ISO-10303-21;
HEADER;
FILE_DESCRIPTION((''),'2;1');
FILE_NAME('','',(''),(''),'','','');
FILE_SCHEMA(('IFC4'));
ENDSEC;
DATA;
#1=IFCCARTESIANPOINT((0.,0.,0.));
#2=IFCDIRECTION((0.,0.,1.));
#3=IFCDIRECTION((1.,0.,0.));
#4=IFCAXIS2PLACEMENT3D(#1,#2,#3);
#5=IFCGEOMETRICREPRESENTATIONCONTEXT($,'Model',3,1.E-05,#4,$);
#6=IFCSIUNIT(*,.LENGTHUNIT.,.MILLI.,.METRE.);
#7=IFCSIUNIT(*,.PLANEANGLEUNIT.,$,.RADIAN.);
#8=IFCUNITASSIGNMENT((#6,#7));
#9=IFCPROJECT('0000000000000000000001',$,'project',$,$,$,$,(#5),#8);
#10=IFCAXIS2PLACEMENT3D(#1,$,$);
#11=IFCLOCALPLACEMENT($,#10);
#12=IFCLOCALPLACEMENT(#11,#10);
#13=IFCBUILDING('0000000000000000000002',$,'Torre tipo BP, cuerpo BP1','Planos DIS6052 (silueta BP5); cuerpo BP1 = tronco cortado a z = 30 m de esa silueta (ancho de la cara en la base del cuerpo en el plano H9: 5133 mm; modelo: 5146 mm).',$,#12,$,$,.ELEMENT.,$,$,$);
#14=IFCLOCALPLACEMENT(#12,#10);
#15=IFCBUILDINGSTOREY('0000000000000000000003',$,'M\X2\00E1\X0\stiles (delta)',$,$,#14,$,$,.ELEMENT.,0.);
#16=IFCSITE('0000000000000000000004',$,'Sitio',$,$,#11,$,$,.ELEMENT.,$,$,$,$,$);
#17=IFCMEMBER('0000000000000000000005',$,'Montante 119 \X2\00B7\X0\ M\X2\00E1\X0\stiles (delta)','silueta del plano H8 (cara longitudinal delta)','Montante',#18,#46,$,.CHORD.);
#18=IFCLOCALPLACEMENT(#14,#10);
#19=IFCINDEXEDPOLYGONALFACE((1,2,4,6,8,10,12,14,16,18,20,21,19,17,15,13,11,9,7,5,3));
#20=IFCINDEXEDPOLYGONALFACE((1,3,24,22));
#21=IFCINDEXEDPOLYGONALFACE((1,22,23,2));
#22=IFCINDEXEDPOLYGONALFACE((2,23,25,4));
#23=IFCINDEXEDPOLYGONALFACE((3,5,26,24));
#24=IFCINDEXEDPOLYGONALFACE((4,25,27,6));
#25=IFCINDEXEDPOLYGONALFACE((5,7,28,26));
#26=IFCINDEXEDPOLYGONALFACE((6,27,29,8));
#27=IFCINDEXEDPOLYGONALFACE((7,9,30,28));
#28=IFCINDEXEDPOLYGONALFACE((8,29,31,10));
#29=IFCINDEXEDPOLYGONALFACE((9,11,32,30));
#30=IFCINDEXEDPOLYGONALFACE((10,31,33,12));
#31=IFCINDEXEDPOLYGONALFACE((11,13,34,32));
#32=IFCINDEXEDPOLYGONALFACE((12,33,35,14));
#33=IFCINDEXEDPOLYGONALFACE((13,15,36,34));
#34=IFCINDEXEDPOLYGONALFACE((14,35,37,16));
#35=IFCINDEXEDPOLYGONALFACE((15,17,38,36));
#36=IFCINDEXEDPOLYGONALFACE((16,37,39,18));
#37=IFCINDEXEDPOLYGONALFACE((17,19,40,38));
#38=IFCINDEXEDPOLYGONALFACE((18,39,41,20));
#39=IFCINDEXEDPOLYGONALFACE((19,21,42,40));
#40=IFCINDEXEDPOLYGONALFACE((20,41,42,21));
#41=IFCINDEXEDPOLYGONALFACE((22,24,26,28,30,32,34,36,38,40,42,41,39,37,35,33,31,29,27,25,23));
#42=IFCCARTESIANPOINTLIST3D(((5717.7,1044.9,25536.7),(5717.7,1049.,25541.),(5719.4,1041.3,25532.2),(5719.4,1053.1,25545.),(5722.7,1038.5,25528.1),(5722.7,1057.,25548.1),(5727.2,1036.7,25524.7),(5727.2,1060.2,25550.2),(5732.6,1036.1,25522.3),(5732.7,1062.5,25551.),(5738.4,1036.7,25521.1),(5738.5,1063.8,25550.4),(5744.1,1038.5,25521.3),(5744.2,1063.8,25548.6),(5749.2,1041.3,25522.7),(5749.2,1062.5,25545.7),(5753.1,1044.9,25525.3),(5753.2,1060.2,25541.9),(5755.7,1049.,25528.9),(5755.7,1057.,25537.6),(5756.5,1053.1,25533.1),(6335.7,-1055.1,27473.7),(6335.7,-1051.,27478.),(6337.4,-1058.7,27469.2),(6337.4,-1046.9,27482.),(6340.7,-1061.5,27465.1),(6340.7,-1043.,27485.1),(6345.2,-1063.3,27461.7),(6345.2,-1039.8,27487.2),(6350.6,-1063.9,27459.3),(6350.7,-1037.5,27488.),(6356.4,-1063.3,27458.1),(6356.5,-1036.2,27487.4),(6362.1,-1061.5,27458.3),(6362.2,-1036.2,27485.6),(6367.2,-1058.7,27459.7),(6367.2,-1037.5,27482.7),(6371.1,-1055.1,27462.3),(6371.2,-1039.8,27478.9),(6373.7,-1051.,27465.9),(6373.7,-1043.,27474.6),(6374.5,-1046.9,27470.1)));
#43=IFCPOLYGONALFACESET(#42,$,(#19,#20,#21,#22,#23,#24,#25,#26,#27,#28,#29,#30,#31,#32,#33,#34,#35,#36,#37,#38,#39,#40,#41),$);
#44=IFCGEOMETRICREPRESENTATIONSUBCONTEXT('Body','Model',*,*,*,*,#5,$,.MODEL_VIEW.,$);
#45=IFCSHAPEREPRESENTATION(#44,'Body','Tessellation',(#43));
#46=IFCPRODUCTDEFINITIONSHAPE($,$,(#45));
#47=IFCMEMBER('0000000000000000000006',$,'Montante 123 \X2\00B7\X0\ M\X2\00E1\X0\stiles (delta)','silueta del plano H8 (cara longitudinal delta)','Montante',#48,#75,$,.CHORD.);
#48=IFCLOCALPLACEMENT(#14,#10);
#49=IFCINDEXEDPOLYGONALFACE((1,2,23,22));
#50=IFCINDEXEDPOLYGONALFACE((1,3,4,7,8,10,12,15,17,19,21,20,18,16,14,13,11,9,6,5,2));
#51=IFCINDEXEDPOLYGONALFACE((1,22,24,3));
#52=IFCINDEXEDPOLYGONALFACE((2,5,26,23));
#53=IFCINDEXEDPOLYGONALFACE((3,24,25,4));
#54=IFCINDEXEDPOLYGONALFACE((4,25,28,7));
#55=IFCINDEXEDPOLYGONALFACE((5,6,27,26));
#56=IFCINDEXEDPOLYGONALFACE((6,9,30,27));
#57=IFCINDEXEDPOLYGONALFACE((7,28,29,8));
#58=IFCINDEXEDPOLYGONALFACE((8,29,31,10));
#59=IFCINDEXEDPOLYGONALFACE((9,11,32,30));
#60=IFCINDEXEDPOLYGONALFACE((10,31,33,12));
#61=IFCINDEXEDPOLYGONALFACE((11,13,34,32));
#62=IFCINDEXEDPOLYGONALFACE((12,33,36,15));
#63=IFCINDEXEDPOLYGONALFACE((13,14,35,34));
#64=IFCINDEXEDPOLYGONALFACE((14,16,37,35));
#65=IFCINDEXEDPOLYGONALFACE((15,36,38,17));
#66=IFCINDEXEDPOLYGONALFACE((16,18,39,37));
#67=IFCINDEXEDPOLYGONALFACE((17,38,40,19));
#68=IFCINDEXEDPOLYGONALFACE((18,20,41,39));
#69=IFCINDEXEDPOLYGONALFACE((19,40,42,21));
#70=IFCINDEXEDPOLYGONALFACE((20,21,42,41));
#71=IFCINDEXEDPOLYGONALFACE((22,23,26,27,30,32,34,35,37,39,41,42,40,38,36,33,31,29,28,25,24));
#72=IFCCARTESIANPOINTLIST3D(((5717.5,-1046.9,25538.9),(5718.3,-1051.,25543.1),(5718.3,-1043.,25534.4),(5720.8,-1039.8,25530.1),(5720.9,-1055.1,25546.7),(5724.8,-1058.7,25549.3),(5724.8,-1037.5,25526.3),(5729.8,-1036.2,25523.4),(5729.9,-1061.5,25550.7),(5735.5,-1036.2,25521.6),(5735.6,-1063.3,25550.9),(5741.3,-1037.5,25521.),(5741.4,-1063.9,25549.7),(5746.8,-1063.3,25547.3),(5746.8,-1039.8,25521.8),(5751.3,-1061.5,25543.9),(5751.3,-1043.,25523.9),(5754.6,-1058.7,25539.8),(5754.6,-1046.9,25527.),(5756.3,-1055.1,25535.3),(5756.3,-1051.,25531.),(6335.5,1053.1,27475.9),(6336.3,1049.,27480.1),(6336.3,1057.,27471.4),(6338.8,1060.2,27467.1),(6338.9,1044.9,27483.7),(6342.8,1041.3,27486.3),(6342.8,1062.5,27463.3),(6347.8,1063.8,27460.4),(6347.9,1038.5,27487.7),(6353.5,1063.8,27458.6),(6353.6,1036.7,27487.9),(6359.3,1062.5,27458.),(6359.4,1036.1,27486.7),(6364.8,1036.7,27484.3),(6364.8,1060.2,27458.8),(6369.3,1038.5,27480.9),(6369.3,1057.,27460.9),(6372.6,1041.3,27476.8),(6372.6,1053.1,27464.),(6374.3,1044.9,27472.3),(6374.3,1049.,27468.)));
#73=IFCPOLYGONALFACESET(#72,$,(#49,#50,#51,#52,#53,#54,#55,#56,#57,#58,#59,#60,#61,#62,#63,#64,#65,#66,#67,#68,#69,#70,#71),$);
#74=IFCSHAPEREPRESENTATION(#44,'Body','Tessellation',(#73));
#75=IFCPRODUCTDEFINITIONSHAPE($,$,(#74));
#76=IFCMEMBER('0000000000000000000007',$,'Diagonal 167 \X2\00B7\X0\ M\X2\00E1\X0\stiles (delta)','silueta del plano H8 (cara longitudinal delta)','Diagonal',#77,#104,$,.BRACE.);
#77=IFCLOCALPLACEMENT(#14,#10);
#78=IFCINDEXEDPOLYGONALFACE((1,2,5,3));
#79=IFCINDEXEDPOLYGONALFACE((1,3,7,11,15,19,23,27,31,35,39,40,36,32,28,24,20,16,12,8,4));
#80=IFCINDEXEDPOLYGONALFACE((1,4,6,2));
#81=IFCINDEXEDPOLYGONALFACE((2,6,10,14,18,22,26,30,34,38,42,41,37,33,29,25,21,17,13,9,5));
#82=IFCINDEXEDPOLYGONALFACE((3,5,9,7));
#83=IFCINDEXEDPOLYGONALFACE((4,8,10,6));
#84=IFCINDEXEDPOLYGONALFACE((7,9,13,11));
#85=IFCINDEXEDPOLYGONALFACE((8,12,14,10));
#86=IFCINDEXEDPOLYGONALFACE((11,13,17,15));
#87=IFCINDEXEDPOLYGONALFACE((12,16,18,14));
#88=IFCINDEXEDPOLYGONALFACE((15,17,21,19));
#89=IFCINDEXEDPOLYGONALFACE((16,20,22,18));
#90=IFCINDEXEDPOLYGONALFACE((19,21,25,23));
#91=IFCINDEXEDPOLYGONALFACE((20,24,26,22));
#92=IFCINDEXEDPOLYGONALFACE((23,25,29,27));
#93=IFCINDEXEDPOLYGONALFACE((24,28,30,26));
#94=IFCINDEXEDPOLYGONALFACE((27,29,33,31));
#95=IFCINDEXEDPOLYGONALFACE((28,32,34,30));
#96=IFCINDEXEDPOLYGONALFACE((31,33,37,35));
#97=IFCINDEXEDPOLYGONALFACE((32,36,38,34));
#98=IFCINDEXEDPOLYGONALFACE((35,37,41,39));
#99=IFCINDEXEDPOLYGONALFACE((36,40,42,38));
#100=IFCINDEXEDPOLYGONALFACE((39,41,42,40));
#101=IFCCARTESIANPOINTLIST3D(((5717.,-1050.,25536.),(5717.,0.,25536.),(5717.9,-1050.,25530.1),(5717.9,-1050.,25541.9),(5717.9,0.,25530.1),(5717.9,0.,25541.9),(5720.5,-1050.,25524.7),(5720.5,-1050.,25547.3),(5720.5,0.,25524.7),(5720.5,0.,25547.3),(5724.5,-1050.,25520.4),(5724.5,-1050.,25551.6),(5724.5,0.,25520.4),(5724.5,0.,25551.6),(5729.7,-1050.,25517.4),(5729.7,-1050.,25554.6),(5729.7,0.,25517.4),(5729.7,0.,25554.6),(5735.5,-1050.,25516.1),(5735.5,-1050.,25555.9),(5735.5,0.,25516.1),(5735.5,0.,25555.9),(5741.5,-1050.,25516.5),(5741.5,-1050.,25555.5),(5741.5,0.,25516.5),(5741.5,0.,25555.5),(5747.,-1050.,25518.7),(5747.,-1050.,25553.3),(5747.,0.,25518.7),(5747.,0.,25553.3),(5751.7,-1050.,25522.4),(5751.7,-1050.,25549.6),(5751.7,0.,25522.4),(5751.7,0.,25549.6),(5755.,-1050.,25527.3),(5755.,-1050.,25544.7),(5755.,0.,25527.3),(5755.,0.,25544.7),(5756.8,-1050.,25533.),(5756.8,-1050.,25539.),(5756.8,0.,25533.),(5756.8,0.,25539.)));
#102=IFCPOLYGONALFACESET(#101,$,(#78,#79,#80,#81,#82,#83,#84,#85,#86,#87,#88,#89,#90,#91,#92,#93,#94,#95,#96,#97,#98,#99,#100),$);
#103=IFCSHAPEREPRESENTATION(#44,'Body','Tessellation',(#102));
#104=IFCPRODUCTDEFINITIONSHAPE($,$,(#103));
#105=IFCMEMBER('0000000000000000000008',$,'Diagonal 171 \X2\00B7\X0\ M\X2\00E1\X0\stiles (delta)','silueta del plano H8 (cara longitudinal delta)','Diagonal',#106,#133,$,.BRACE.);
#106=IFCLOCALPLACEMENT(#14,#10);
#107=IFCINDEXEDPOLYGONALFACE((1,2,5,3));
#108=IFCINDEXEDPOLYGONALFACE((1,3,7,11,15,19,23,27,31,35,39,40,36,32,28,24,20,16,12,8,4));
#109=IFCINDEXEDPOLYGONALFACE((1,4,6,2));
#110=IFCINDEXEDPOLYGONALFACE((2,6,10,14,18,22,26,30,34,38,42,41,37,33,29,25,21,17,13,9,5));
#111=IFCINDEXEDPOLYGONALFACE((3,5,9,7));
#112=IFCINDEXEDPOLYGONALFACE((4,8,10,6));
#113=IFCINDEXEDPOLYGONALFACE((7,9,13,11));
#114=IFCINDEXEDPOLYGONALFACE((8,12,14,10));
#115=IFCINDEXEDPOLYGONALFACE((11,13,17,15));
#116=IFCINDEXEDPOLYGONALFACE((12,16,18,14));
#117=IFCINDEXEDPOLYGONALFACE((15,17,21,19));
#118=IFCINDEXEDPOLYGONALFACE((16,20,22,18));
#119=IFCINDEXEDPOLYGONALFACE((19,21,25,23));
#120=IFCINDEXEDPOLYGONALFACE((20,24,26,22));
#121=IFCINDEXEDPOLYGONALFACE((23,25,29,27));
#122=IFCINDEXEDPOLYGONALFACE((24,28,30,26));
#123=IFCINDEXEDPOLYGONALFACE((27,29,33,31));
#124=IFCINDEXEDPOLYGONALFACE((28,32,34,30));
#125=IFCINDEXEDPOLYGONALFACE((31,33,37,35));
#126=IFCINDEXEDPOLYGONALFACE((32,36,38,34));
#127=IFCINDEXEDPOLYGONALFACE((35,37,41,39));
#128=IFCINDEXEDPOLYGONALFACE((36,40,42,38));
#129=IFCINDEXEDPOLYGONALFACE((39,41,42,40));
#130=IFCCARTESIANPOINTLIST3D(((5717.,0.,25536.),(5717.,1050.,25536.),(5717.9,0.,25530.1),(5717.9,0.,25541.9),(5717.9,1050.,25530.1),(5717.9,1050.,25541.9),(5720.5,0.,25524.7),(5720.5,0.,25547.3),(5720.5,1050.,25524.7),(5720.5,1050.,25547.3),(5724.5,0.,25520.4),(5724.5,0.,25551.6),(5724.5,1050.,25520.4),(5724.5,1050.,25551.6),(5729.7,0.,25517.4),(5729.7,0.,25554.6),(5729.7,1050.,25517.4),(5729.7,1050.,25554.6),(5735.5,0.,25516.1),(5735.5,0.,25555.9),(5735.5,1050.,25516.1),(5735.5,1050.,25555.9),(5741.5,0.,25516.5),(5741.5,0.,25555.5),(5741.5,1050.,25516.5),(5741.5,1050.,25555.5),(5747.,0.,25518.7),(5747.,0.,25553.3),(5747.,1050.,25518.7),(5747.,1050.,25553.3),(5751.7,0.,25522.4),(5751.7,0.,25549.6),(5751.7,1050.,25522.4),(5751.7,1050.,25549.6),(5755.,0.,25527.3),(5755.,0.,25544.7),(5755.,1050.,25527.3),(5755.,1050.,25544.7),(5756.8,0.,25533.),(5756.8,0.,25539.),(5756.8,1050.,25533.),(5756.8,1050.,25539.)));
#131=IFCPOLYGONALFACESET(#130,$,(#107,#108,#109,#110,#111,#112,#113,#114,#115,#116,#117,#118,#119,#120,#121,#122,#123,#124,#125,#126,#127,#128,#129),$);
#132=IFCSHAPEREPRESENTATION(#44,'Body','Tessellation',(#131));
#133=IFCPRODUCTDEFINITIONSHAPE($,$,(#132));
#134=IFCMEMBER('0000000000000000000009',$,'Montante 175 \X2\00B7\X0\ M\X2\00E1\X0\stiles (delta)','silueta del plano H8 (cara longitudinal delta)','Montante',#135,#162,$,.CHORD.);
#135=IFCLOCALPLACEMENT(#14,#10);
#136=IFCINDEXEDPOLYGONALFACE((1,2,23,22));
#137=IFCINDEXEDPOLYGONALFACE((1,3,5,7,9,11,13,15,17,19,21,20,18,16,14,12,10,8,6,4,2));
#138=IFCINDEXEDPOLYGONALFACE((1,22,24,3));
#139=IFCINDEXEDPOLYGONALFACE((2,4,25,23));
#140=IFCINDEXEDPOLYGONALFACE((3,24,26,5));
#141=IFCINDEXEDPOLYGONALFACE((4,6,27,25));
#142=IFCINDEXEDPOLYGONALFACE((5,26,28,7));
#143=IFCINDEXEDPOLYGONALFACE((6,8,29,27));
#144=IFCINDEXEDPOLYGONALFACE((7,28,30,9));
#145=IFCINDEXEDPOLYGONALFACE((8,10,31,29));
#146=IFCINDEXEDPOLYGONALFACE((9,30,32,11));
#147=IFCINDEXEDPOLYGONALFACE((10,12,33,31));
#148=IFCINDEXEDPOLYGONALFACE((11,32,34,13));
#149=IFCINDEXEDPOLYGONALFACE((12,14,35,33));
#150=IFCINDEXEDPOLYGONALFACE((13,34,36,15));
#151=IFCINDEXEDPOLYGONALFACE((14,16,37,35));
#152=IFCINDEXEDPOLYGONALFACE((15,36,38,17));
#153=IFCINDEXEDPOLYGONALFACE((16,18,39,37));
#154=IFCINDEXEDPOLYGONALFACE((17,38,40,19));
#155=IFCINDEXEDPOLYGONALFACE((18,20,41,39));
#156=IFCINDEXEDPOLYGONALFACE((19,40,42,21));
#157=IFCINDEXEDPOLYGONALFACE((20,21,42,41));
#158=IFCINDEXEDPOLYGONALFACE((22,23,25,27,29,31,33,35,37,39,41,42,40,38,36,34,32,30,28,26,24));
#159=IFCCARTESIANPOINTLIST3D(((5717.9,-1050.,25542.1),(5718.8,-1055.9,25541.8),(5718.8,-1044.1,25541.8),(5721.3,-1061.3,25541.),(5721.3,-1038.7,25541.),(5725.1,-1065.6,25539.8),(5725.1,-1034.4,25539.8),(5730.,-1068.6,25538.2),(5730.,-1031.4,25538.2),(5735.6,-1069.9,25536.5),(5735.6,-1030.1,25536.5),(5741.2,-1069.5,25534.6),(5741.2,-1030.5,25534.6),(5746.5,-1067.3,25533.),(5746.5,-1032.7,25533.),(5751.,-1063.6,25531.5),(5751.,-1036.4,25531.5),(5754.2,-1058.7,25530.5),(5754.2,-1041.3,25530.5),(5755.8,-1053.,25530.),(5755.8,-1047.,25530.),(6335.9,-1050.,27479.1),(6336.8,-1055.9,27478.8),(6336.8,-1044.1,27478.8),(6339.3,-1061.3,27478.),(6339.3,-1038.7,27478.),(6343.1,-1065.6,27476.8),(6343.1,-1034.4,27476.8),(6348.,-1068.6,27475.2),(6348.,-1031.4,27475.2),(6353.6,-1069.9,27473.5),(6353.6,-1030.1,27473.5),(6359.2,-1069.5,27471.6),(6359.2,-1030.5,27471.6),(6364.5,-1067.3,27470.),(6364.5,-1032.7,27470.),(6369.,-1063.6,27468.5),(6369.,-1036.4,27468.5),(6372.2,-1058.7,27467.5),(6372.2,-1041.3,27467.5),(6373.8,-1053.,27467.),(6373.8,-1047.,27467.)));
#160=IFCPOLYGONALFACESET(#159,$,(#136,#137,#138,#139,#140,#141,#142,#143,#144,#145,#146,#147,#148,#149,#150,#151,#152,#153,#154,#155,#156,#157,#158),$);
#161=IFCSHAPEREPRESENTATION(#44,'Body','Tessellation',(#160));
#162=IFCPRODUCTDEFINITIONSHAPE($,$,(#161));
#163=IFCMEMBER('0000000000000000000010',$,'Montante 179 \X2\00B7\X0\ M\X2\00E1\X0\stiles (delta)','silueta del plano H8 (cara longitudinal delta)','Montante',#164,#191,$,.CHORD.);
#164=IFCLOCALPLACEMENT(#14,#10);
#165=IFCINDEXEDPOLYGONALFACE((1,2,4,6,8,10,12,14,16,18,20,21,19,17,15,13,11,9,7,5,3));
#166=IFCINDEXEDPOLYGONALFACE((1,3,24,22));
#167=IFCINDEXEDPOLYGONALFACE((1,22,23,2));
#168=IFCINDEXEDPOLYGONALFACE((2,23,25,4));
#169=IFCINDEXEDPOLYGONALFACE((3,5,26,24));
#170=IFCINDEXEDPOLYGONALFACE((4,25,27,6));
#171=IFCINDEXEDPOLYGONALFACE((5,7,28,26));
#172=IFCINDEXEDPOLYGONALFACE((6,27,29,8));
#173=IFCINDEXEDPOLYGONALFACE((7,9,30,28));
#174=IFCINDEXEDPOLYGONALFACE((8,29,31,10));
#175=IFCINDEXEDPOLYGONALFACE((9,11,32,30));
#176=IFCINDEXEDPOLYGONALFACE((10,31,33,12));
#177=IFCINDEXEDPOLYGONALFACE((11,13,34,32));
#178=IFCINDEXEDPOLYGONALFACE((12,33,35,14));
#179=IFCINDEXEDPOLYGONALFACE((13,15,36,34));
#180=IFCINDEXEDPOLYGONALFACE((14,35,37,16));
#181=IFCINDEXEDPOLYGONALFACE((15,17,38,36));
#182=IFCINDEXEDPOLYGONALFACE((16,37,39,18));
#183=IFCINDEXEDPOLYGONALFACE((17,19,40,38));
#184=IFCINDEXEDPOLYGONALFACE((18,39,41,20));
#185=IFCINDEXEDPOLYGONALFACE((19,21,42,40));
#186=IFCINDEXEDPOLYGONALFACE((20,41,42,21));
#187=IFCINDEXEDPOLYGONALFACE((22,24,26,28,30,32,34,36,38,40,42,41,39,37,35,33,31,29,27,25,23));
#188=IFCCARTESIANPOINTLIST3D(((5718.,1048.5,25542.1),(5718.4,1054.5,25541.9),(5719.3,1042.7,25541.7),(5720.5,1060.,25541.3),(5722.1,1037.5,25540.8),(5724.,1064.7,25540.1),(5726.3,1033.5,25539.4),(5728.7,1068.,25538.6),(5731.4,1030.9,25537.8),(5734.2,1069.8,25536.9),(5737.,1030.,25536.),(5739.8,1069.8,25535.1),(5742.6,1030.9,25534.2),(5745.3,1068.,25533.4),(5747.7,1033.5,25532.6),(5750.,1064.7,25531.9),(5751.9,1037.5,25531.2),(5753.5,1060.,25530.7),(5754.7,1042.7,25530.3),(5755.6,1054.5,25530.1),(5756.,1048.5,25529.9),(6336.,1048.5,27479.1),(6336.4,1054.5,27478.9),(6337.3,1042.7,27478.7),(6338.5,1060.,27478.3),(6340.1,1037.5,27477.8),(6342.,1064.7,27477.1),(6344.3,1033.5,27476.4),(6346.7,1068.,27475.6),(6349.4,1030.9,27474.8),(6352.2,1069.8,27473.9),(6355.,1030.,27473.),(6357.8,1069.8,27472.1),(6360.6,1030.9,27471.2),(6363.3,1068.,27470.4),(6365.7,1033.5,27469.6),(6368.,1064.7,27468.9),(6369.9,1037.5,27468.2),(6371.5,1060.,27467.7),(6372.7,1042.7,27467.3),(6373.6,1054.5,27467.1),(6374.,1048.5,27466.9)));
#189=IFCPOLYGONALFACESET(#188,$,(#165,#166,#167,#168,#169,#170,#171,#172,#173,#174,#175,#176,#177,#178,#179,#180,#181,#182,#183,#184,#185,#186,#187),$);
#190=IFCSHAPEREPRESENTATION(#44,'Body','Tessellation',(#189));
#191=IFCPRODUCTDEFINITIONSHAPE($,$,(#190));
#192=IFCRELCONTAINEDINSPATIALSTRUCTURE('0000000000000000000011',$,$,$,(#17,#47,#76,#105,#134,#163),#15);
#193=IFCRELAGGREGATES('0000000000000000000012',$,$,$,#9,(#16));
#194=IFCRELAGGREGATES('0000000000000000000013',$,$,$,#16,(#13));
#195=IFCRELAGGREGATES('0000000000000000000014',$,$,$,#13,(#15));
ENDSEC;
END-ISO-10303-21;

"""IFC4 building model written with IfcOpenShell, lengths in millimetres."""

from ifc_helpers import new_model, si_unit, frame, origin, origin_with_axes, place, context, subcontext, project, spatial, circle, extrude, element, save


model = new_model("IFC4")

# Units and contexts
model_context = context("Model", 3, precision=1e-05, world=origin_with_axes())
body_context = subcontext(model_context, "Body", "Model", "MODEL_VIEW")
ifc_project = project(units=[si_unit("LENGTHUNIT", "METRE", prefix="MILLI"), si_unit("PLANEANGLEUNIT", "RADIAN")], contexts=[model_context])

# Site, building, storey
site_placement = place(None, origin())
site = spatial("IfcSite", under=ifc_project, at=site_placement, Name="Sitio", CompositionType="ELEMENT")
building_placement = place(site_placement, origin())
building = spatial("IfcBuilding", under=site, at=building_placement, Name="Torre tipo BP, cuerpo BP1", Description="Planos DIS6052 (silueta BP5); cuerpo BP1 = tronco cortado a z = 30 m de esa silueta (ancho de la cara en la base del cuerpo en el plano H9: 5133 mm; modelo: 5146 mm).", CompositionType="ELEMENT")
storey_placement = place(building_placement, origin())
storey = spatial("IfcBuildingStorey", under=building, at=storey_placement, Name="Mástiles (delta)", CompositionType="ELEMENT", Elevation=0.0)

# Members
for number, where, z_axis, x_axis, name in (
    (1, (6355.0, -1050.0, 27473.0), (-0.211427, 0.718441, -0.662677), (-0.218374, -0.695587, -0.684449), "Montante 119 · Mástiles (delta)"),
    (2, (6355.0, 1050.0, 27473.0), (-0.211427, -0.718441, -0.662677), (0.218374, -0.695587, 0.684449), "Montante 123 · Mástiles (delta)"),
):
    element("IfcMember", number, at=place(storey_placement, frame(where, z_axis=z_axis, x_axis=x_axis)), inside=storey, Name=name, Description="silueta del plano H8 (cara longitudinal delta)", ObjectType="Montante", PredefinedType="CHORD", context=body_context, shape_type="SweptSolid", body=[
        extrude(circle(Radius=20.0), None, (0.0, 0.0, 1.0), 2923.0),
    ])
for number, where, z_axis, x_axis, name in (
    (3, (5737.0, -1050.0, 25536.0), (0.0, 1.0, 0.0), (-1.0, 0.0, 0.0), "Diagonal 167 · Mástiles (delta)"),
    (4, (5737.0, 1050.0, 25536.0), (0.0, -1.0, 0.0), (-1.0, 0.0, 0.0), "Diagonal 171 · Mástiles (delta)"),
):
    element("IfcMember", number, at=place(storey_placement, frame(where, z_axis=z_axis, x_axis=x_axis)), inside=storey, Name=name, Description="silueta del plano H8 (cara longitudinal delta)", ObjectType="Diagonal", PredefinedType="BRACE", context=body_context, shape_type="SweptSolid", body=[
        extrude(circle(Radius=20.0), None, (0.0, 0.0, 1.0), 1050.0),
    ])
for number, where, z_axis, x_axis, name in (
    (5, (6355.0, -1050.0, 27473.0), (-0.303955, 0.0, -0.952686), (-0.952686, 0.0, 0.303955), "Montante 175 · Mástiles (delta)"),
    (6, (6355.0, 1050.0, 27473.0), (-0.303955, 0.0, -0.952686), (0.0, -1.0, 0.0), "Montante 179 · Mástiles (delta)"),
):
    element("IfcMember", number, at=place(storey_placement, frame(where, z_axis=z_axis, x_axis=x_axis)), inside=storey, Name=name, Description="silueta del plano H8 (cara longitudinal delta)", ObjectType="Montante", PredefinedType="CHORD", context=body_context, shape_type="SweptSolid", body=[
        extrude(circle(Radius=20.0), None, (0.0, 0.0, 1.0), 2033.2),
    ])

save(model, "model.ifc")
